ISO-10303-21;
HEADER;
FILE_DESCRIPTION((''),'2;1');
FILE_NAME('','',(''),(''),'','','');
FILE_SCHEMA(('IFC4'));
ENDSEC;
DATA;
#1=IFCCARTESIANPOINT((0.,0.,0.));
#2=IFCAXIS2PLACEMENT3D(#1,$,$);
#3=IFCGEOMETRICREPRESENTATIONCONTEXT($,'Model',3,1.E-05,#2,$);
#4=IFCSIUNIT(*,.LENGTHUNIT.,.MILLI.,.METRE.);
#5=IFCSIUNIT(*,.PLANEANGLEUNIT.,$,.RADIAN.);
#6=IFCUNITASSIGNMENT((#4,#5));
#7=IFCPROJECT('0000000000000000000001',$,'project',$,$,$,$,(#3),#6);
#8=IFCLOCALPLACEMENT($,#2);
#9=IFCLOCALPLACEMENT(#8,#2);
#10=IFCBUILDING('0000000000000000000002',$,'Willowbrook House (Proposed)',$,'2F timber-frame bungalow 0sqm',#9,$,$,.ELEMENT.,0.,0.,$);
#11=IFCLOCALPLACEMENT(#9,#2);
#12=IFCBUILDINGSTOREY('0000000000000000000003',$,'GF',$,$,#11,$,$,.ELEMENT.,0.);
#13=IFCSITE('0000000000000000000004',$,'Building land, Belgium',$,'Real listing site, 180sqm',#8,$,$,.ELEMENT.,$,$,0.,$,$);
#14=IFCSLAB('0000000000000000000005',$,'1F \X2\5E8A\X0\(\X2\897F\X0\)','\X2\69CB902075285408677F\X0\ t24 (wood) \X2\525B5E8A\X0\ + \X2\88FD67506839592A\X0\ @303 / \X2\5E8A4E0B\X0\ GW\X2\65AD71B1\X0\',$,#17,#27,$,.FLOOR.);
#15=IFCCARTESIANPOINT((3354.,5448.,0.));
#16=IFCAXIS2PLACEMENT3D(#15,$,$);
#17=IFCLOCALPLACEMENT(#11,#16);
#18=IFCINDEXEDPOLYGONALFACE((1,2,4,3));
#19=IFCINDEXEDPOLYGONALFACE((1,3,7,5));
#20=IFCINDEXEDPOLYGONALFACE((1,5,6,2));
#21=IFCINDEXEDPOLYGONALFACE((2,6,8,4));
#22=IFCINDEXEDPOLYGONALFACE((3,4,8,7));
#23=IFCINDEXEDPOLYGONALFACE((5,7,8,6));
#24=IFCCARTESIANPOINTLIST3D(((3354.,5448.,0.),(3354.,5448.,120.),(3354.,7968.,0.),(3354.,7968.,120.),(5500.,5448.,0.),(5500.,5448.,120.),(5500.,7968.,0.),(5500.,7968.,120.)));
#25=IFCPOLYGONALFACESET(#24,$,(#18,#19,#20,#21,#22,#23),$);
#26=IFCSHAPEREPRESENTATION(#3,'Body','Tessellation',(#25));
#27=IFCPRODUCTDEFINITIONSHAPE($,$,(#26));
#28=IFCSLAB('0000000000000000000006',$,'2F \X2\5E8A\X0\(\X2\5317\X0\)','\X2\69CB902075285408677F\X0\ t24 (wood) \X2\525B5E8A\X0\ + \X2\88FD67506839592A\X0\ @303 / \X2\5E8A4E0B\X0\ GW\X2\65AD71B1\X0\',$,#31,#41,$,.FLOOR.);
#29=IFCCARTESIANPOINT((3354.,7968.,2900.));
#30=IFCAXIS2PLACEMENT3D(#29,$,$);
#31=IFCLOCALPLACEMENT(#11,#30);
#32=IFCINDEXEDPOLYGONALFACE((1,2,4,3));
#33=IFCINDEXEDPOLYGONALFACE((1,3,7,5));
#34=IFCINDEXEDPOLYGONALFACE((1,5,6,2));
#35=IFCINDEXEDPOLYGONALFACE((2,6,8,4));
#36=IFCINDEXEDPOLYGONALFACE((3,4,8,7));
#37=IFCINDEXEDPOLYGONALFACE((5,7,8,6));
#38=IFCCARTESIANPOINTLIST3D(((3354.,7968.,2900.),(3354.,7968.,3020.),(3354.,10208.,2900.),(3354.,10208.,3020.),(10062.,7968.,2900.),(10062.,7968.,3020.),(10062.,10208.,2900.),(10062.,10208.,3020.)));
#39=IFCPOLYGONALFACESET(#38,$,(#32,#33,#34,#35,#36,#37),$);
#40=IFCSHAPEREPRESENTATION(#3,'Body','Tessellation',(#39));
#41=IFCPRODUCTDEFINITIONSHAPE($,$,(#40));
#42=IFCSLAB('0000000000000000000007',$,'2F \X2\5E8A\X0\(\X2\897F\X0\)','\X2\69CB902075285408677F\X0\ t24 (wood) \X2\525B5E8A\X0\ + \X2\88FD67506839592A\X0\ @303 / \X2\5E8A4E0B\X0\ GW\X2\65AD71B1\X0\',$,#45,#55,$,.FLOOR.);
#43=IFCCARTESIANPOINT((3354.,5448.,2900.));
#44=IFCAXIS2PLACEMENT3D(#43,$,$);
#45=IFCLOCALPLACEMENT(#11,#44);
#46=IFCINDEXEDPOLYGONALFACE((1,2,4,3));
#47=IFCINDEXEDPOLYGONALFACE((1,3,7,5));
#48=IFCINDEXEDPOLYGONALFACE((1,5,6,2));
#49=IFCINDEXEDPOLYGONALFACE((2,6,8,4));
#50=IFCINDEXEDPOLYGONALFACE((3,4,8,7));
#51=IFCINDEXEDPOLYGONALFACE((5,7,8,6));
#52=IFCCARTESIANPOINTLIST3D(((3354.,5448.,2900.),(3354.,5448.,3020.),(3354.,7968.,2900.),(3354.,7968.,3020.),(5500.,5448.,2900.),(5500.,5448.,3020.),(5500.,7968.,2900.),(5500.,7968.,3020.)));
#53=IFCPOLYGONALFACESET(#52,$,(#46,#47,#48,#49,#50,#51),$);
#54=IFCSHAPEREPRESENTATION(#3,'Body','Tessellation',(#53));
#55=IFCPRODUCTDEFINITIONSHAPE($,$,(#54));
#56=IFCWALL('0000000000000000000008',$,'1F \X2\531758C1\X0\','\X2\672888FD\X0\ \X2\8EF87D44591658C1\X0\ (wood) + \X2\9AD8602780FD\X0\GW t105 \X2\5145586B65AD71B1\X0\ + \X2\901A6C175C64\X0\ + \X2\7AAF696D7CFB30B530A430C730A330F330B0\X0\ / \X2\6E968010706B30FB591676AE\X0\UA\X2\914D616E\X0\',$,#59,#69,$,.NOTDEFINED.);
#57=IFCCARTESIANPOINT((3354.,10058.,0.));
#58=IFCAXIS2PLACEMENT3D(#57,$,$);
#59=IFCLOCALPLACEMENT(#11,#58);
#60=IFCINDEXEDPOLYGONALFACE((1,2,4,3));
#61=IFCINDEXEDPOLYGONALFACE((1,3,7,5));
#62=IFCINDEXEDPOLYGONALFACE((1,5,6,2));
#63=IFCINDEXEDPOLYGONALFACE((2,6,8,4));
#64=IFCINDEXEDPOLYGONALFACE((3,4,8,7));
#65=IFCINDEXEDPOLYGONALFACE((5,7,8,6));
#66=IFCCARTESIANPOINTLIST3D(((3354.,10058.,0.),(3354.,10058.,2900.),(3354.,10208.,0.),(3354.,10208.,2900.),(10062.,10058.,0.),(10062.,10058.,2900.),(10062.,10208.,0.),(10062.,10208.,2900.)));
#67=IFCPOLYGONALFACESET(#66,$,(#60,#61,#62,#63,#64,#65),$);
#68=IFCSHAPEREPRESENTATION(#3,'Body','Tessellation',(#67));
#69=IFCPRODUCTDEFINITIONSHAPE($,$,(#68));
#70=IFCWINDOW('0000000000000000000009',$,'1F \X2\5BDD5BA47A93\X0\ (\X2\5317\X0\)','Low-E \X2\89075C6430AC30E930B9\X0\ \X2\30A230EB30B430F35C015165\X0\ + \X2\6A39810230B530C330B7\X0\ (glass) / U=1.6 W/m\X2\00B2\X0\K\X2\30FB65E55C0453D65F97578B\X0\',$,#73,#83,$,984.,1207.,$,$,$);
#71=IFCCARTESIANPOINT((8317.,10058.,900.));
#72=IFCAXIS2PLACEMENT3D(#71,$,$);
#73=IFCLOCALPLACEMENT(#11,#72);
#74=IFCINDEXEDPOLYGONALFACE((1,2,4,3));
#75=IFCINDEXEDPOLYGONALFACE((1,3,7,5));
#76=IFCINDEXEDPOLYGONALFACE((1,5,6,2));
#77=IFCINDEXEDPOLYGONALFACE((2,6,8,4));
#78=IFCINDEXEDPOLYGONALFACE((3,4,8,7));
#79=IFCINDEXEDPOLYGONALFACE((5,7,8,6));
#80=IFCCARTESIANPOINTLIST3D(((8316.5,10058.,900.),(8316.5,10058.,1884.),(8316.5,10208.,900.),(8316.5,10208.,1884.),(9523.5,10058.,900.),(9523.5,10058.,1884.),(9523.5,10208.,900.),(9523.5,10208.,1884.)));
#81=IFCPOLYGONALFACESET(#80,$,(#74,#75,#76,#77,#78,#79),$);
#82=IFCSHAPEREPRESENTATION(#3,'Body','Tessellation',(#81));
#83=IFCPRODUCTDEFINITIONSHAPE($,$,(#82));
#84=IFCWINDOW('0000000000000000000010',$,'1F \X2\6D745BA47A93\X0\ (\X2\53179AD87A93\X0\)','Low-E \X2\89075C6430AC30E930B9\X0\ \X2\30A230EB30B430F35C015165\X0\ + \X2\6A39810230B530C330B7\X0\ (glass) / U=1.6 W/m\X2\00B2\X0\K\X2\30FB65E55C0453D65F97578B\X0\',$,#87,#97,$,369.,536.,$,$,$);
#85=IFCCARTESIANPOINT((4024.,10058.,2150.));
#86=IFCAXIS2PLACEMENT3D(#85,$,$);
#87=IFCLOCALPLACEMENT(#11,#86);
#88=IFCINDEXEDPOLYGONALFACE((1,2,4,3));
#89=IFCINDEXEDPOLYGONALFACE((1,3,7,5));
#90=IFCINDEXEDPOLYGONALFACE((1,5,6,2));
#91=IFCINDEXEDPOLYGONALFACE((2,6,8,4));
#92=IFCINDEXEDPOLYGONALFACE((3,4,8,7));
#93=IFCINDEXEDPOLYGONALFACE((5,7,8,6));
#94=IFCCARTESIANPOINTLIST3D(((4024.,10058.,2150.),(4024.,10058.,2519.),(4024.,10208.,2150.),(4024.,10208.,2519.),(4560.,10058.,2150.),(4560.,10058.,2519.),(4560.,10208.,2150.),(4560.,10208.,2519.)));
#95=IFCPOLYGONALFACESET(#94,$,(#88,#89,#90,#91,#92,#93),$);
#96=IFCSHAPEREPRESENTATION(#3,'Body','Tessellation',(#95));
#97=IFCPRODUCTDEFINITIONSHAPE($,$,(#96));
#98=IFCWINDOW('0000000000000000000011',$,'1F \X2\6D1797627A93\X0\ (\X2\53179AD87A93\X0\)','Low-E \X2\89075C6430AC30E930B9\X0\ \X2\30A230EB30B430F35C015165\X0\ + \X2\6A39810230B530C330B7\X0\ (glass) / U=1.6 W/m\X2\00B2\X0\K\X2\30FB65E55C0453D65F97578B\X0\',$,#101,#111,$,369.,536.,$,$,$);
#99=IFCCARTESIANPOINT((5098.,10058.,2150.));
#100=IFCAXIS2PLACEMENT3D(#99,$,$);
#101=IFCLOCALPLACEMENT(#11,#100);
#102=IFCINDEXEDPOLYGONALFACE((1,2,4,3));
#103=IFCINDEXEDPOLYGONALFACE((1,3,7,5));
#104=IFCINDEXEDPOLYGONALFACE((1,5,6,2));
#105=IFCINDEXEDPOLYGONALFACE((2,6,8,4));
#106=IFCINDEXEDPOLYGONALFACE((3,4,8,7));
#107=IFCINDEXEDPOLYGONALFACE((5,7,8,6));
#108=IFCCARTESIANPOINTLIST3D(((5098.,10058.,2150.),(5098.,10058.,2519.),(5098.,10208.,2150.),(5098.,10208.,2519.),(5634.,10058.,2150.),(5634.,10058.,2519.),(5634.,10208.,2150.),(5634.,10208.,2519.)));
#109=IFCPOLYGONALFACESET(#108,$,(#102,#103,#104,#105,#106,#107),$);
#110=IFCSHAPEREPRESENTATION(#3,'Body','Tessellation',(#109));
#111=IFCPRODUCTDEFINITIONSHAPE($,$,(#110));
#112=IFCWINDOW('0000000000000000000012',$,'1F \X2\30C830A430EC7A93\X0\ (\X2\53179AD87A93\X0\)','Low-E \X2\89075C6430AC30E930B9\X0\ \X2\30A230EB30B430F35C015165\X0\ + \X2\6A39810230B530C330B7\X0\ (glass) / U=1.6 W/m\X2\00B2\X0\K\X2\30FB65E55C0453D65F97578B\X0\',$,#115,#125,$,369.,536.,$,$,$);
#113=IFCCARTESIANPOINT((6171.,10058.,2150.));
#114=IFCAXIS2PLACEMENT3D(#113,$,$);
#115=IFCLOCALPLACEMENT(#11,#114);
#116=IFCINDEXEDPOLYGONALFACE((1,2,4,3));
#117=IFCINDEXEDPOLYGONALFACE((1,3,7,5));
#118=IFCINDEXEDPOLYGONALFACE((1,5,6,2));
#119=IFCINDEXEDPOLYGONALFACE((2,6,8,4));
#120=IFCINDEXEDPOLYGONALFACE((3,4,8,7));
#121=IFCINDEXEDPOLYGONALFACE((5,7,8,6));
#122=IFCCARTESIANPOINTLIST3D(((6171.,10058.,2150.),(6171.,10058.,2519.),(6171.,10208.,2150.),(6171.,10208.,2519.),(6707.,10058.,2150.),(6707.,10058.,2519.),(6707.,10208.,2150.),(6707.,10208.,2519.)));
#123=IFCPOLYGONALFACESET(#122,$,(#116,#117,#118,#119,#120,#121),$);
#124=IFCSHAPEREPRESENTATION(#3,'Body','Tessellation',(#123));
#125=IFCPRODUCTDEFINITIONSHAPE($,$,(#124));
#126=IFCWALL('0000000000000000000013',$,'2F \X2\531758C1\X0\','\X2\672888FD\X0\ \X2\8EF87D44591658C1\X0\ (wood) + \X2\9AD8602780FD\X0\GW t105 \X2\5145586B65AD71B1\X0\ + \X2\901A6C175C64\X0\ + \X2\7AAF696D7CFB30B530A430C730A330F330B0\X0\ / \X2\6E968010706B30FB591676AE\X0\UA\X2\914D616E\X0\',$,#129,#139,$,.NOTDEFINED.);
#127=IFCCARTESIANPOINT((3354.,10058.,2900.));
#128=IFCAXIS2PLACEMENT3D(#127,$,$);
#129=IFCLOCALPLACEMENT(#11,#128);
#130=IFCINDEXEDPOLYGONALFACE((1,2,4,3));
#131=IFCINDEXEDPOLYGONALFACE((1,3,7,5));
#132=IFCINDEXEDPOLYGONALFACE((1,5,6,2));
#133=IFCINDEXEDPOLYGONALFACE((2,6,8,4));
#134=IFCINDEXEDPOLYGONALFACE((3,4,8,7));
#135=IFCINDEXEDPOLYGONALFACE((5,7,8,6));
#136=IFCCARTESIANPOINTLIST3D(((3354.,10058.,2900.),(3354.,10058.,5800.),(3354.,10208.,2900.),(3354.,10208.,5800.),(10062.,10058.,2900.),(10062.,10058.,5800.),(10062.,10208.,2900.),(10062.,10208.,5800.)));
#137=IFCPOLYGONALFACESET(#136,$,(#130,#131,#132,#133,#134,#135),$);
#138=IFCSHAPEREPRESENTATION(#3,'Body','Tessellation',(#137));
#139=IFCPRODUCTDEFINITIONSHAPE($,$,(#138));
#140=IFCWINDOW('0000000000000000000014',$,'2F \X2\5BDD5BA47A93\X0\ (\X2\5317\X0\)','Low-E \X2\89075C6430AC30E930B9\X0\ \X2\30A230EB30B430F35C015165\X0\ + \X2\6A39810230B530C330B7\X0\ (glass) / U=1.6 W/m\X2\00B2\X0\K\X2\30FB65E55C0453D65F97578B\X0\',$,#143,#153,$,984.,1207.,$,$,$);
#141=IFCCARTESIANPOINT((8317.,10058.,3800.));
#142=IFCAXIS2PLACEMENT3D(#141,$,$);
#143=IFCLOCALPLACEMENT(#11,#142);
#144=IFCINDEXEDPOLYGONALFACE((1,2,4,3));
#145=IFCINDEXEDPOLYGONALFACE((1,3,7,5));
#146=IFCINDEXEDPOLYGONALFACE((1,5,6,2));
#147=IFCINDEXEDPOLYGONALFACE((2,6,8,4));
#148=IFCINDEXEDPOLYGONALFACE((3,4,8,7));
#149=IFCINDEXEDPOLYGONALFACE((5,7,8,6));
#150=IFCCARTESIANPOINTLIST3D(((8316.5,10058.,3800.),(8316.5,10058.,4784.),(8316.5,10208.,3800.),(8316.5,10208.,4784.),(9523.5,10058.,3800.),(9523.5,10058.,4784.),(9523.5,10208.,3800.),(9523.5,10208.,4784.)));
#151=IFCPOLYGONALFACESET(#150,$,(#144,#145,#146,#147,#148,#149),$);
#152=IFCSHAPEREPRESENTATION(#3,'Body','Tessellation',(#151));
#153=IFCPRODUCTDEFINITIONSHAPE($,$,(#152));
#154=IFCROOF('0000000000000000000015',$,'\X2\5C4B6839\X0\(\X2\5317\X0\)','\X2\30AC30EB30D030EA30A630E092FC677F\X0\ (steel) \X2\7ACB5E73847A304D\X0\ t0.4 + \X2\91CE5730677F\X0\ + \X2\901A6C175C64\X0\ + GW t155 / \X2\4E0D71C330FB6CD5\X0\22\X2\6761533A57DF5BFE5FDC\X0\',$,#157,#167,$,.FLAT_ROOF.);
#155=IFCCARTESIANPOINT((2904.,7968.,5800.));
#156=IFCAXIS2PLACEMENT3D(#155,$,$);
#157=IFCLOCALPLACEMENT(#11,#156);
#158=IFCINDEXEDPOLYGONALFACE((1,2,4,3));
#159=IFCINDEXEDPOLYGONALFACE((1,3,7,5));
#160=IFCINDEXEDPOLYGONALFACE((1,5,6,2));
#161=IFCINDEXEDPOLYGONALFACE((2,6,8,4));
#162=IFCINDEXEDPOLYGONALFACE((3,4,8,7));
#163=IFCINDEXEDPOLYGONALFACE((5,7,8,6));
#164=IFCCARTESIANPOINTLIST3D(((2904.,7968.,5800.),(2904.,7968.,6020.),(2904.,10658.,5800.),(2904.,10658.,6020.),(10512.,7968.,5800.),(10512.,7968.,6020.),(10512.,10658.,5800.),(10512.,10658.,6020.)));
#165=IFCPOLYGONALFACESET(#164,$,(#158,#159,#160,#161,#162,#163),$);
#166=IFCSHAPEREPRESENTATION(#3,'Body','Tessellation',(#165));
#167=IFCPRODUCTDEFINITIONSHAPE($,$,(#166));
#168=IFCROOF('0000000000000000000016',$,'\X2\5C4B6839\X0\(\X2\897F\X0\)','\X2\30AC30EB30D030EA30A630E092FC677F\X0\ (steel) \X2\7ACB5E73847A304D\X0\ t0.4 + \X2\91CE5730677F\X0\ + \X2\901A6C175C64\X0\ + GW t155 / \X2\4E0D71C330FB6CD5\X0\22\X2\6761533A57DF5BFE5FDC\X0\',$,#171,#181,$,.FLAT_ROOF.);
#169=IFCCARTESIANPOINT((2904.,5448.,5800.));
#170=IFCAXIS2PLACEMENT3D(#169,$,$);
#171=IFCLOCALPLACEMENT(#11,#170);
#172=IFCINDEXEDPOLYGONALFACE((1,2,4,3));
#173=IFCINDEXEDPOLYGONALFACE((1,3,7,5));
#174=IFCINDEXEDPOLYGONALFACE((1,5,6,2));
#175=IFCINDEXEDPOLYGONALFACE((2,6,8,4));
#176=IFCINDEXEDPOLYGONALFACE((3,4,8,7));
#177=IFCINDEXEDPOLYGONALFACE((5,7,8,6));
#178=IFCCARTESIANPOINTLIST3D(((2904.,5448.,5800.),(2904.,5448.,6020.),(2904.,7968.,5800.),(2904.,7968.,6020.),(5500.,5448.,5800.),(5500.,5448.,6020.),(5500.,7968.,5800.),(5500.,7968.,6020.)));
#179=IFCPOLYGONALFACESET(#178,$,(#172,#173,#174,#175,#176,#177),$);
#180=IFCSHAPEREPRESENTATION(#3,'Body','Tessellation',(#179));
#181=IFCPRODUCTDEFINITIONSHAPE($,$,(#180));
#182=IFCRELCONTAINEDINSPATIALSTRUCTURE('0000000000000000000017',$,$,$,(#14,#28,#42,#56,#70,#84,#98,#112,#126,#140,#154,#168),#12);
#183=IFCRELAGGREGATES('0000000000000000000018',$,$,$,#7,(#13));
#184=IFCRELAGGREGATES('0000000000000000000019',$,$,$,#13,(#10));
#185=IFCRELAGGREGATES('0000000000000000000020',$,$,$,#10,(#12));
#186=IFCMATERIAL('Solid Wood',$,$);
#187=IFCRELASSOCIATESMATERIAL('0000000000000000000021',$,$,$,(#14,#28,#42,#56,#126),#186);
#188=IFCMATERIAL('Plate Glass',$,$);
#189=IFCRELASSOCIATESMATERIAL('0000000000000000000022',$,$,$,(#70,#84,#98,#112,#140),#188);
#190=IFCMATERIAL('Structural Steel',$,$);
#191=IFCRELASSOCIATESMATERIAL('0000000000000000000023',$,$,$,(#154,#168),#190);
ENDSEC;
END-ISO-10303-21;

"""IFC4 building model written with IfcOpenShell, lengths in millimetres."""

from ifc_helpers import new_model, si_unit, frame, frame_2d, origin, place, context, project, spatial, rectangle, extrude, material, element, fill, save


model = new_model("IFC4")

# Units and contexts
model_context = context("Model", 3, precision=1e-05, world=origin())
ifc_project = project(units=[si_unit("LENGTHUNIT", "METRE", prefix="MILLI"), si_unit("PLANEANGLEUNIT", "RADIAN")], contexts=[model_context])

# Site, building, storey
site_placement = place(None, origin())
site = spatial("IfcSite", under=ifc_project, at=site_placement, Name="Building land, Belgium", ObjectType="Real listing site, 180sqm", CompositionType="ELEMENT", RefElevation=0.0)
building_placement = place(site_placement, origin())
building = spatial("IfcBuilding", under=site, at=building_placement, Name="Willowbrook House (Proposed)", ObjectType="2F timber-frame bungalow 0sqm", CompositionType="ELEMENT", ElevationOfRefHeight=0.0, ElevationOfTerrain=0.0)
storey_placement = place(building_placement, origin())
storey = spatial("IfcBuildingStorey", under=building, at=storey_placement, Name="GF", CompositionType="ELEMENT", Elevation=0.0)

# Slabs
ifc_material_1 = material(Name="Solid Wood")
slab_1_placement = place(storey_placement, frame((3354.0, 5448.0, 0.0)))
element("IfcSlab", 1, at=slab_1_placement, inside=storey, material=ifc_material_1, Name="1F 床(西)", Description="構造用合板 t24 (wood) 剛床 + 製材根太 @303 / 床下 GW断熱", PredefinedType="FLOOR", context=model_context, shape_type="SweptSolid", body=[
    extrude(rectangle(XDim=2146.0, YDim=2520.0, at=frame_2d((1073.0, 1260.0))), frame((3354.0, 5448.0, 0.0)), (0.0, 0.0, 1.0), 120.0),
])
slab_2_placement = place(storey_placement, frame((3354.0, 7968.0, 2900.0)))
element("IfcSlab", 2, at=slab_2_placement, inside=storey, material=ifc_material_1, Name="2F 床(北)", Description="構造用合板 t24 (wood) 剛床 + 製材根太 @303 / 床下 GW断熱", PredefinedType="FLOOR", context=model_context, shape_type="SweptSolid", body=[
    extrude(rectangle(XDim=6708.0, YDim=2240.0, at=frame_2d((3354.0, 1120.0))), frame((3354.0, 7968.0, 2900.0)), (0.0, 0.0, 1.0), 120.0),
])
slab_3_placement = place(storey_placement, frame((3354.0, 5448.0, 2900.0)))
element("IfcSlab", 3, at=slab_3_placement, inside=storey, material=ifc_material_1, Name="2F 床(西)", Description="構造用合板 t24 (wood) 剛床 + 製材根太 @303 / 床下 GW断熱", PredefinedType="FLOOR", context=model_context, shape_type="SweptSolid", body=[
    extrude(rectangle(XDim=2146.0, YDim=2520.0, at=frame_2d((1073.0, 1260.0))), frame((3354.0, 5448.0, 2900.0)), (0.0, 0.0, 1.0), 120.0),
])

# Wall, openings, windows
wall_1_placement = place(storey_placement, frame((3354.0, 10058.0, 0.0)))
wall_1 = element("IfcWall", 4, at=wall_1_placement, inside=storey, material=ifc_material_1, Name="1F 北壁", Description="木製 軸組外壁 (wood) + 高性能GW t105 充填断熱 + 通気層 + 窯業系サイディング / 準耐火・外皮UA配慮", PredefinedType="NOTDEFINED", context=model_context, shape_type="SweptSolid", body=[
    extrude(rectangle(XDim=6708.0, YDim=150.0, at=frame_2d((3354.0, 75.0))), frame((3354.0, 10058.0, 0.0)), (0.0, 0.0, 1.0), 2900.0),
])
opening_1_placement = place(storey_placement, frame((8317.0, 10058.0, 900.0)))
opening_1 = element("IfcOpeningElement", 5, at=opening_1_placement, cuts=wall_1, PredefinedType="NOTDEFINED", context=model_context, shape_type="SweptSolid", body=[
    extrude(rectangle(XDim=1207.0, YDim=150.0, at=frame_2d((603.0, 75.0))), frame((8317.0, 10058.0, 900.0)), (0.0, 0.0, 1.0), 984.0),
])
opening_2_placement = place(storey_placement, frame((4024.0, 10058.0, 2150.0)))
opening_2 = element("IfcOpeningElement", 6, at=opening_2_placement, cuts=wall_1, PredefinedType="NOTDEFINED", context=model_context, shape_type="SweptSolid", body=[
    extrude(rectangle(XDim=536.0, YDim=150.0, at=frame_2d((268.0, 75.0))), frame((4024.0, 10058.0, 2150.0)), (0.0, 0.0, 1.0), 369.0),
])
opening_3_placement = place(storey_placement, frame((5098.0, 10058.0, 2150.0)))
opening_3 = element("IfcOpeningElement", 7, at=opening_3_placement, cuts=wall_1, PredefinedType="NOTDEFINED", context=model_context, shape_type="SweptSolid", body=[
    extrude(rectangle(XDim=536.0, YDim=150.0, at=frame_2d((268.0, 75.0))), frame((5098.0, 10058.0, 2150.0)), (0.0, 0.0, 1.0), 369.0),
])
opening_4_placement = place(storey_placement, frame((6171.0, 10058.0, 2150.0)))
opening_4 = element("IfcOpeningElement", 8, at=opening_4_placement, cuts=wall_1, PredefinedType="NOTDEFINED", context=model_context, shape_type="SweptSolid", body=[
    extrude(rectangle(XDim=536.0, YDim=150.0, at=frame_2d((268.0, 75.0))), frame((6171.0, 10058.0, 2150.0)), (0.0, 0.0, 1.0), 369.0),
])
ifc_material_2 = material(Name="Plate Glass")
window_1_placement = place(storey_placement, frame((8317.0, 10058.0, 900.0)))
window_1 = element("IfcWindow", 9, at=window_1_placement, inside=storey, material=ifc_material_2, Name="1F 寝室窓 (北)", Description="Low-E 複層ガラス アルゴン封入 + 樹脂サッシ (glass) / U=1.6 W/m²K・日射取得型", OverallHeight=984.0, OverallWidth=1207.0, context=model_context, shape_type="SweptSolid", body=[
    extrude(rectangle(XDim=1207.0, YDim=150.0, at=frame_2d((603.0, 75.0))), frame((8317.0, 10058.0, 900.0)), (0.0, 0.0, 1.0), 984.0),
])
fill(opening_1, window_1)
window_2_placement = place(storey_placement, frame((4024.0, 10058.0, 2150.0)))
window_2 = element("IfcWindow", 10, at=window_2_placement, inside=storey, material=ifc_material_2, Name="1F 浴室窓 (北高窓)", Description="Low-E 複層ガラス アルゴン封入 + 樹脂サッシ (glass) / U=1.6 W/m²K・日射取得型", OverallHeight=369.0, OverallWidth=536.0, context=model_context, shape_type="SweptSolid", body=[
    extrude(rectangle(XDim=536.0, YDim=150.0, at=frame_2d((268.0, 75.0))), frame((4024.0, 10058.0, 2150.0)), (0.0, 0.0, 1.0), 369.0),
])
fill(opening_2, window_2)
window_3_placement = place(storey_placement, frame((5098.0, 10058.0, 2150.0)))
window_3 = element("IfcWindow", 11, at=window_3_placement, inside=storey, material=ifc_material_2, Name="1F 洗面窓 (北高窓)", Description="Low-E 複層ガラス アルゴン封入 + 樹脂サッシ (glass) / U=1.6 W/m²K・日射取得型", OverallHeight=369.0, OverallWidth=536.0, context=model_context, shape_type="SweptSolid", body=[
    extrude(rectangle(XDim=536.0, YDim=150.0, at=frame_2d((268.0, 75.0))), frame((5098.0, 10058.0, 2150.0)), (0.0, 0.0, 1.0), 369.0),
])
fill(opening_3, window_3)
window_4_placement = place(storey_placement, frame((6171.0, 10058.0, 2150.0)))
window_4 = element("IfcWindow", 12, at=window_4_placement, inside=storey, material=ifc_material_2, Name="1F トイレ窓 (北高窓)", Description="Low-E 複層ガラス アルゴン封入 + 樹脂サッシ (glass) / U=1.6 W/m²K・日射取得型", OverallHeight=369.0, OverallWidth=536.0, context=model_context, shape_type="SweptSolid", body=[
    extrude(rectangle(XDim=536.0, YDim=150.0, at=frame_2d((268.0, 75.0))), frame((6171.0, 10058.0, 2150.0)), (0.0, 0.0, 1.0), 369.0),
])
fill(opening_4, window_4)

# Wall, opening, window
wall_2_placement = place(storey_placement, frame((3354.0, 10058.0, 2900.0)))
wall_2 = element("IfcWall", 13, at=wall_2_placement, inside=storey, material=ifc_material_1, Name="2F 北壁", Description="木製 軸組外壁 (wood) + 高性能GW t105 充填断熱 + 通気層 + 窯業系サイディング / 準耐火・外皮UA配慮", PredefinedType="NOTDEFINED", context=model_context, shape_type="SweptSolid", body=[
    extrude(rectangle(XDim=6708.0, YDim=150.0, at=frame_2d((3354.0, 75.0))), frame((3354.0, 10058.0, 2900.0)), (0.0, 0.0, 1.0), 2900.0),
])
opening_5_placement = place(storey_placement, frame((8317.0, 10058.0, 3800.0)))
opening_5 = element("IfcOpeningElement", 14, at=opening_5_placement, cuts=wall_2, PredefinedType="NOTDEFINED", context=model_context, shape_type="SweptSolid", body=[
    extrude(rectangle(XDim=1207.0, YDim=150.0, at=frame_2d((603.0, 75.0))), frame((8317.0, 10058.0, 3800.0)), (0.0, 0.0, 1.0), 984.0),
])
window_5_placement = place(storey_placement, frame((8317.0, 10058.0, 3800.0)))
window_5 = element("IfcWindow", 15, at=window_5_placement, inside=storey, material=ifc_material_2, Name="2F 寝室窓 (北)", Description="Low-E 複層ガラス アルゴン封入 + 樹脂サッシ (glass) / U=1.6 W/m²K・日射取得型", OverallHeight=984.0, OverallWidth=1207.0, context=model_context, shape_type="SweptSolid", body=[
    extrude(rectangle(XDim=1207.0, YDim=150.0, at=frame_2d((603.0, 75.0))), frame((8317.0, 10058.0, 3800.0)), (0.0, 0.0, 1.0), 984.0),
])
fill(opening_5, window_5)

# Roofs
ifc_material_3 = material(Name="Structural Steel")
for number, where, name in (
    (16, (2904.0, 7968.0, 5800.0), "屋根(北)"),
):
    element("IfcRoof", number, at=place(storey_placement, frame(where)), inside=storey, material=ifc_material_3, Name=name, Description="ガルバリウム鋼板 (steel) 立平葺き t0.4 + 野地板 + 通気層 + GW t155 / 不燃・法22条区域対応", PredefinedType="FLAT_ROOF", context=model_context, shape_type="SweptSolid", body=[
        extrude(rectangle(XDim=7608.0, YDim=2690.0, at=frame_2d((3804.0, 1345.0))), frame((2904.0, 7968.0, 5800.0)), (0.0, 0.0, 1.0), 220.0),
    ])
roof_placement = place(storey_placement, frame((2904.0, 5448.0, 5800.0)))
element("IfcRoof", 17, at=roof_placement, inside=storey, material=ifc_material_3, Name="屋根(西)", Description="ガルバリウム鋼板 (steel) 立平葺き t0.4 + 野地板 + 通気層 + GW t155 / 不燃・法22条区域対応", PredefinedType="FLAT_ROOF", context=model_context, shape_type="SweptSolid", body=[
    extrude(rectangle(XDim=2596.0, YDim=2520.0, at=frame_2d((1298.0, 1260.0))), frame((2904.0, 5448.0, 5800.0)), (0.0, 0.0, 1.0), 220.0),
])

save(model, "model.ifc")
